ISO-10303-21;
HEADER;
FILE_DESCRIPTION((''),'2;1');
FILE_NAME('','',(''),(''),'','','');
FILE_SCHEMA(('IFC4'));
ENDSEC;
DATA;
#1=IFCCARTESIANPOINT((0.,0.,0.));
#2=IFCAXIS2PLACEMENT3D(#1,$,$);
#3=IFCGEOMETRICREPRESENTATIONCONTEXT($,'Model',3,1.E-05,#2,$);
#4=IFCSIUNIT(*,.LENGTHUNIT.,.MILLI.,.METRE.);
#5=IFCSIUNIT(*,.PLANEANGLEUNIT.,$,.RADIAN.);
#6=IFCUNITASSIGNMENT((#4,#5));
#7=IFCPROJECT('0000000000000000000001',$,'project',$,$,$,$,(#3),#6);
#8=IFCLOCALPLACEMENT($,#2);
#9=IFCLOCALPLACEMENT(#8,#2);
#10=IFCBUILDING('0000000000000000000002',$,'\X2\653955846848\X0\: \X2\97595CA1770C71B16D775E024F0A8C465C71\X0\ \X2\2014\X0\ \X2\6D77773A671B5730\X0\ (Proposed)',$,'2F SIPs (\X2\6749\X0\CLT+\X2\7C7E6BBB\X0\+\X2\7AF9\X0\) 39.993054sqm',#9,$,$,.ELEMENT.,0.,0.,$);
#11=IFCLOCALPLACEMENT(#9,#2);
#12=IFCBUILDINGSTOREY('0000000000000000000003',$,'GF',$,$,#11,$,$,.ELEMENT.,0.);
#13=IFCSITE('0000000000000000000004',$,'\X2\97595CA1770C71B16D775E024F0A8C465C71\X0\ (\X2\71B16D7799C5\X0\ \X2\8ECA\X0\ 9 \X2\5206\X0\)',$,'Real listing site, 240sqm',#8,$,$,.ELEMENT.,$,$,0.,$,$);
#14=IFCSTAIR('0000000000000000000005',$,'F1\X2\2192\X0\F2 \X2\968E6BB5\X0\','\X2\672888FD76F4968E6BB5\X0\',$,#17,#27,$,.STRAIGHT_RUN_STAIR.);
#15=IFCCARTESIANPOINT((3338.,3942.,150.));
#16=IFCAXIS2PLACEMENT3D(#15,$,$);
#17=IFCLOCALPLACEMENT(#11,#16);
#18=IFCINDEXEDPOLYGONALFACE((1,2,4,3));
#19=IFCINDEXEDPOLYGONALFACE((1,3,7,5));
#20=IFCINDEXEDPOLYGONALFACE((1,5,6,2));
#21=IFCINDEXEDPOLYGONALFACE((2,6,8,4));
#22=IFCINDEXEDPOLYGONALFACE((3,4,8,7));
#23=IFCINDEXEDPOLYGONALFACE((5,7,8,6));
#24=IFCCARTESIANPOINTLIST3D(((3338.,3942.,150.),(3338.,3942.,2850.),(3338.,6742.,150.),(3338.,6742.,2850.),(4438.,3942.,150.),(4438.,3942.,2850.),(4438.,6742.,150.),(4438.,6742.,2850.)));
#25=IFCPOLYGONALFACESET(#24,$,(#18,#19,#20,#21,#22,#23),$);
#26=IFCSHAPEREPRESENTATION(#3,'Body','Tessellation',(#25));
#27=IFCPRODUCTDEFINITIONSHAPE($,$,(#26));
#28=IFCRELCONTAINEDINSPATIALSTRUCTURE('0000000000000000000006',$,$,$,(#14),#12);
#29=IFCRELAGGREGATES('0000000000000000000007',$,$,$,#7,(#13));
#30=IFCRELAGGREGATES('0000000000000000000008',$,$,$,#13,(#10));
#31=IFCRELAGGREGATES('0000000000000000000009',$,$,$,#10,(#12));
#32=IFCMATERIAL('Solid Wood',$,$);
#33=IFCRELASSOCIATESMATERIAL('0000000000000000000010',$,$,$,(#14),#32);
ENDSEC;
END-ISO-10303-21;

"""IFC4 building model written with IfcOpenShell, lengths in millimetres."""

from ifc_helpers import new_model, si_unit, frame, frame_2d, origin, place, context, project, spatial, rectangle, extrude, material, element, save


model = new_model("IFC4")

# Units and contexts
model_context = context("Model", 3, precision=1e-05, world=origin())
ifc_project = project(units=[si_unit("LENGTHUNIT", "METRE", prefix="MILLI"), si_unit("PLANEANGLEUNIT", "RADIAN")], contexts=[model_context])

# Site, building, storey
site_placement = place(None, origin())
site = spatial("IfcSite", under=ifc_project, at=site_placement, Name="静岡県熱海市伊豆山 (熱海駅 車 9 分)", ObjectType="Real listing site, 240sqm", CompositionType="ELEMENT", RefElevation=0.0)
building_placement = place(site_placement, origin())
building = spatial("IfcBuilding", under=site, at=building_placement, Name="改善案: 静岡県熱海市伊豆山 — 海眺望地 (Proposed)", ObjectType="2F SIPs (杉CLT+籾殻+竹) 39.993054sqm", CompositionType="ELEMENT", ElevationOfRefHeight=0.0, ElevationOfTerrain=0.0)
storey_placement = place(building_placement, origin())
storey = spatial("IfcBuildingStorey", under=building, at=storey_placement, Name="GF", CompositionType="ELEMENT", Elevation=0.0)

# Shared definitions
ifc_material_1 = material(Name="Solid Wood")

# Stair
stair_placement = place(storey_placement, frame((3338.0, 3942.0, 150.0)))
element("IfcStair", 1, at=stair_placement, inside=storey, material=ifc_material_1, Name="F1→F2 階段", Description="木製直階段", PredefinedType="STRAIGHT_RUN_STAIR", context=model_context, shape_type="SweptSolid", body=[
    extrude(rectangle(XDim=1100.0, YDim=2800.0, at=frame_2d((550.0, 1400.0))), frame((3338.0, 3942.0, 150.0)), (0.0, 0.0, 1.0), 2700.0),
])

save(model, "model.ifc")
